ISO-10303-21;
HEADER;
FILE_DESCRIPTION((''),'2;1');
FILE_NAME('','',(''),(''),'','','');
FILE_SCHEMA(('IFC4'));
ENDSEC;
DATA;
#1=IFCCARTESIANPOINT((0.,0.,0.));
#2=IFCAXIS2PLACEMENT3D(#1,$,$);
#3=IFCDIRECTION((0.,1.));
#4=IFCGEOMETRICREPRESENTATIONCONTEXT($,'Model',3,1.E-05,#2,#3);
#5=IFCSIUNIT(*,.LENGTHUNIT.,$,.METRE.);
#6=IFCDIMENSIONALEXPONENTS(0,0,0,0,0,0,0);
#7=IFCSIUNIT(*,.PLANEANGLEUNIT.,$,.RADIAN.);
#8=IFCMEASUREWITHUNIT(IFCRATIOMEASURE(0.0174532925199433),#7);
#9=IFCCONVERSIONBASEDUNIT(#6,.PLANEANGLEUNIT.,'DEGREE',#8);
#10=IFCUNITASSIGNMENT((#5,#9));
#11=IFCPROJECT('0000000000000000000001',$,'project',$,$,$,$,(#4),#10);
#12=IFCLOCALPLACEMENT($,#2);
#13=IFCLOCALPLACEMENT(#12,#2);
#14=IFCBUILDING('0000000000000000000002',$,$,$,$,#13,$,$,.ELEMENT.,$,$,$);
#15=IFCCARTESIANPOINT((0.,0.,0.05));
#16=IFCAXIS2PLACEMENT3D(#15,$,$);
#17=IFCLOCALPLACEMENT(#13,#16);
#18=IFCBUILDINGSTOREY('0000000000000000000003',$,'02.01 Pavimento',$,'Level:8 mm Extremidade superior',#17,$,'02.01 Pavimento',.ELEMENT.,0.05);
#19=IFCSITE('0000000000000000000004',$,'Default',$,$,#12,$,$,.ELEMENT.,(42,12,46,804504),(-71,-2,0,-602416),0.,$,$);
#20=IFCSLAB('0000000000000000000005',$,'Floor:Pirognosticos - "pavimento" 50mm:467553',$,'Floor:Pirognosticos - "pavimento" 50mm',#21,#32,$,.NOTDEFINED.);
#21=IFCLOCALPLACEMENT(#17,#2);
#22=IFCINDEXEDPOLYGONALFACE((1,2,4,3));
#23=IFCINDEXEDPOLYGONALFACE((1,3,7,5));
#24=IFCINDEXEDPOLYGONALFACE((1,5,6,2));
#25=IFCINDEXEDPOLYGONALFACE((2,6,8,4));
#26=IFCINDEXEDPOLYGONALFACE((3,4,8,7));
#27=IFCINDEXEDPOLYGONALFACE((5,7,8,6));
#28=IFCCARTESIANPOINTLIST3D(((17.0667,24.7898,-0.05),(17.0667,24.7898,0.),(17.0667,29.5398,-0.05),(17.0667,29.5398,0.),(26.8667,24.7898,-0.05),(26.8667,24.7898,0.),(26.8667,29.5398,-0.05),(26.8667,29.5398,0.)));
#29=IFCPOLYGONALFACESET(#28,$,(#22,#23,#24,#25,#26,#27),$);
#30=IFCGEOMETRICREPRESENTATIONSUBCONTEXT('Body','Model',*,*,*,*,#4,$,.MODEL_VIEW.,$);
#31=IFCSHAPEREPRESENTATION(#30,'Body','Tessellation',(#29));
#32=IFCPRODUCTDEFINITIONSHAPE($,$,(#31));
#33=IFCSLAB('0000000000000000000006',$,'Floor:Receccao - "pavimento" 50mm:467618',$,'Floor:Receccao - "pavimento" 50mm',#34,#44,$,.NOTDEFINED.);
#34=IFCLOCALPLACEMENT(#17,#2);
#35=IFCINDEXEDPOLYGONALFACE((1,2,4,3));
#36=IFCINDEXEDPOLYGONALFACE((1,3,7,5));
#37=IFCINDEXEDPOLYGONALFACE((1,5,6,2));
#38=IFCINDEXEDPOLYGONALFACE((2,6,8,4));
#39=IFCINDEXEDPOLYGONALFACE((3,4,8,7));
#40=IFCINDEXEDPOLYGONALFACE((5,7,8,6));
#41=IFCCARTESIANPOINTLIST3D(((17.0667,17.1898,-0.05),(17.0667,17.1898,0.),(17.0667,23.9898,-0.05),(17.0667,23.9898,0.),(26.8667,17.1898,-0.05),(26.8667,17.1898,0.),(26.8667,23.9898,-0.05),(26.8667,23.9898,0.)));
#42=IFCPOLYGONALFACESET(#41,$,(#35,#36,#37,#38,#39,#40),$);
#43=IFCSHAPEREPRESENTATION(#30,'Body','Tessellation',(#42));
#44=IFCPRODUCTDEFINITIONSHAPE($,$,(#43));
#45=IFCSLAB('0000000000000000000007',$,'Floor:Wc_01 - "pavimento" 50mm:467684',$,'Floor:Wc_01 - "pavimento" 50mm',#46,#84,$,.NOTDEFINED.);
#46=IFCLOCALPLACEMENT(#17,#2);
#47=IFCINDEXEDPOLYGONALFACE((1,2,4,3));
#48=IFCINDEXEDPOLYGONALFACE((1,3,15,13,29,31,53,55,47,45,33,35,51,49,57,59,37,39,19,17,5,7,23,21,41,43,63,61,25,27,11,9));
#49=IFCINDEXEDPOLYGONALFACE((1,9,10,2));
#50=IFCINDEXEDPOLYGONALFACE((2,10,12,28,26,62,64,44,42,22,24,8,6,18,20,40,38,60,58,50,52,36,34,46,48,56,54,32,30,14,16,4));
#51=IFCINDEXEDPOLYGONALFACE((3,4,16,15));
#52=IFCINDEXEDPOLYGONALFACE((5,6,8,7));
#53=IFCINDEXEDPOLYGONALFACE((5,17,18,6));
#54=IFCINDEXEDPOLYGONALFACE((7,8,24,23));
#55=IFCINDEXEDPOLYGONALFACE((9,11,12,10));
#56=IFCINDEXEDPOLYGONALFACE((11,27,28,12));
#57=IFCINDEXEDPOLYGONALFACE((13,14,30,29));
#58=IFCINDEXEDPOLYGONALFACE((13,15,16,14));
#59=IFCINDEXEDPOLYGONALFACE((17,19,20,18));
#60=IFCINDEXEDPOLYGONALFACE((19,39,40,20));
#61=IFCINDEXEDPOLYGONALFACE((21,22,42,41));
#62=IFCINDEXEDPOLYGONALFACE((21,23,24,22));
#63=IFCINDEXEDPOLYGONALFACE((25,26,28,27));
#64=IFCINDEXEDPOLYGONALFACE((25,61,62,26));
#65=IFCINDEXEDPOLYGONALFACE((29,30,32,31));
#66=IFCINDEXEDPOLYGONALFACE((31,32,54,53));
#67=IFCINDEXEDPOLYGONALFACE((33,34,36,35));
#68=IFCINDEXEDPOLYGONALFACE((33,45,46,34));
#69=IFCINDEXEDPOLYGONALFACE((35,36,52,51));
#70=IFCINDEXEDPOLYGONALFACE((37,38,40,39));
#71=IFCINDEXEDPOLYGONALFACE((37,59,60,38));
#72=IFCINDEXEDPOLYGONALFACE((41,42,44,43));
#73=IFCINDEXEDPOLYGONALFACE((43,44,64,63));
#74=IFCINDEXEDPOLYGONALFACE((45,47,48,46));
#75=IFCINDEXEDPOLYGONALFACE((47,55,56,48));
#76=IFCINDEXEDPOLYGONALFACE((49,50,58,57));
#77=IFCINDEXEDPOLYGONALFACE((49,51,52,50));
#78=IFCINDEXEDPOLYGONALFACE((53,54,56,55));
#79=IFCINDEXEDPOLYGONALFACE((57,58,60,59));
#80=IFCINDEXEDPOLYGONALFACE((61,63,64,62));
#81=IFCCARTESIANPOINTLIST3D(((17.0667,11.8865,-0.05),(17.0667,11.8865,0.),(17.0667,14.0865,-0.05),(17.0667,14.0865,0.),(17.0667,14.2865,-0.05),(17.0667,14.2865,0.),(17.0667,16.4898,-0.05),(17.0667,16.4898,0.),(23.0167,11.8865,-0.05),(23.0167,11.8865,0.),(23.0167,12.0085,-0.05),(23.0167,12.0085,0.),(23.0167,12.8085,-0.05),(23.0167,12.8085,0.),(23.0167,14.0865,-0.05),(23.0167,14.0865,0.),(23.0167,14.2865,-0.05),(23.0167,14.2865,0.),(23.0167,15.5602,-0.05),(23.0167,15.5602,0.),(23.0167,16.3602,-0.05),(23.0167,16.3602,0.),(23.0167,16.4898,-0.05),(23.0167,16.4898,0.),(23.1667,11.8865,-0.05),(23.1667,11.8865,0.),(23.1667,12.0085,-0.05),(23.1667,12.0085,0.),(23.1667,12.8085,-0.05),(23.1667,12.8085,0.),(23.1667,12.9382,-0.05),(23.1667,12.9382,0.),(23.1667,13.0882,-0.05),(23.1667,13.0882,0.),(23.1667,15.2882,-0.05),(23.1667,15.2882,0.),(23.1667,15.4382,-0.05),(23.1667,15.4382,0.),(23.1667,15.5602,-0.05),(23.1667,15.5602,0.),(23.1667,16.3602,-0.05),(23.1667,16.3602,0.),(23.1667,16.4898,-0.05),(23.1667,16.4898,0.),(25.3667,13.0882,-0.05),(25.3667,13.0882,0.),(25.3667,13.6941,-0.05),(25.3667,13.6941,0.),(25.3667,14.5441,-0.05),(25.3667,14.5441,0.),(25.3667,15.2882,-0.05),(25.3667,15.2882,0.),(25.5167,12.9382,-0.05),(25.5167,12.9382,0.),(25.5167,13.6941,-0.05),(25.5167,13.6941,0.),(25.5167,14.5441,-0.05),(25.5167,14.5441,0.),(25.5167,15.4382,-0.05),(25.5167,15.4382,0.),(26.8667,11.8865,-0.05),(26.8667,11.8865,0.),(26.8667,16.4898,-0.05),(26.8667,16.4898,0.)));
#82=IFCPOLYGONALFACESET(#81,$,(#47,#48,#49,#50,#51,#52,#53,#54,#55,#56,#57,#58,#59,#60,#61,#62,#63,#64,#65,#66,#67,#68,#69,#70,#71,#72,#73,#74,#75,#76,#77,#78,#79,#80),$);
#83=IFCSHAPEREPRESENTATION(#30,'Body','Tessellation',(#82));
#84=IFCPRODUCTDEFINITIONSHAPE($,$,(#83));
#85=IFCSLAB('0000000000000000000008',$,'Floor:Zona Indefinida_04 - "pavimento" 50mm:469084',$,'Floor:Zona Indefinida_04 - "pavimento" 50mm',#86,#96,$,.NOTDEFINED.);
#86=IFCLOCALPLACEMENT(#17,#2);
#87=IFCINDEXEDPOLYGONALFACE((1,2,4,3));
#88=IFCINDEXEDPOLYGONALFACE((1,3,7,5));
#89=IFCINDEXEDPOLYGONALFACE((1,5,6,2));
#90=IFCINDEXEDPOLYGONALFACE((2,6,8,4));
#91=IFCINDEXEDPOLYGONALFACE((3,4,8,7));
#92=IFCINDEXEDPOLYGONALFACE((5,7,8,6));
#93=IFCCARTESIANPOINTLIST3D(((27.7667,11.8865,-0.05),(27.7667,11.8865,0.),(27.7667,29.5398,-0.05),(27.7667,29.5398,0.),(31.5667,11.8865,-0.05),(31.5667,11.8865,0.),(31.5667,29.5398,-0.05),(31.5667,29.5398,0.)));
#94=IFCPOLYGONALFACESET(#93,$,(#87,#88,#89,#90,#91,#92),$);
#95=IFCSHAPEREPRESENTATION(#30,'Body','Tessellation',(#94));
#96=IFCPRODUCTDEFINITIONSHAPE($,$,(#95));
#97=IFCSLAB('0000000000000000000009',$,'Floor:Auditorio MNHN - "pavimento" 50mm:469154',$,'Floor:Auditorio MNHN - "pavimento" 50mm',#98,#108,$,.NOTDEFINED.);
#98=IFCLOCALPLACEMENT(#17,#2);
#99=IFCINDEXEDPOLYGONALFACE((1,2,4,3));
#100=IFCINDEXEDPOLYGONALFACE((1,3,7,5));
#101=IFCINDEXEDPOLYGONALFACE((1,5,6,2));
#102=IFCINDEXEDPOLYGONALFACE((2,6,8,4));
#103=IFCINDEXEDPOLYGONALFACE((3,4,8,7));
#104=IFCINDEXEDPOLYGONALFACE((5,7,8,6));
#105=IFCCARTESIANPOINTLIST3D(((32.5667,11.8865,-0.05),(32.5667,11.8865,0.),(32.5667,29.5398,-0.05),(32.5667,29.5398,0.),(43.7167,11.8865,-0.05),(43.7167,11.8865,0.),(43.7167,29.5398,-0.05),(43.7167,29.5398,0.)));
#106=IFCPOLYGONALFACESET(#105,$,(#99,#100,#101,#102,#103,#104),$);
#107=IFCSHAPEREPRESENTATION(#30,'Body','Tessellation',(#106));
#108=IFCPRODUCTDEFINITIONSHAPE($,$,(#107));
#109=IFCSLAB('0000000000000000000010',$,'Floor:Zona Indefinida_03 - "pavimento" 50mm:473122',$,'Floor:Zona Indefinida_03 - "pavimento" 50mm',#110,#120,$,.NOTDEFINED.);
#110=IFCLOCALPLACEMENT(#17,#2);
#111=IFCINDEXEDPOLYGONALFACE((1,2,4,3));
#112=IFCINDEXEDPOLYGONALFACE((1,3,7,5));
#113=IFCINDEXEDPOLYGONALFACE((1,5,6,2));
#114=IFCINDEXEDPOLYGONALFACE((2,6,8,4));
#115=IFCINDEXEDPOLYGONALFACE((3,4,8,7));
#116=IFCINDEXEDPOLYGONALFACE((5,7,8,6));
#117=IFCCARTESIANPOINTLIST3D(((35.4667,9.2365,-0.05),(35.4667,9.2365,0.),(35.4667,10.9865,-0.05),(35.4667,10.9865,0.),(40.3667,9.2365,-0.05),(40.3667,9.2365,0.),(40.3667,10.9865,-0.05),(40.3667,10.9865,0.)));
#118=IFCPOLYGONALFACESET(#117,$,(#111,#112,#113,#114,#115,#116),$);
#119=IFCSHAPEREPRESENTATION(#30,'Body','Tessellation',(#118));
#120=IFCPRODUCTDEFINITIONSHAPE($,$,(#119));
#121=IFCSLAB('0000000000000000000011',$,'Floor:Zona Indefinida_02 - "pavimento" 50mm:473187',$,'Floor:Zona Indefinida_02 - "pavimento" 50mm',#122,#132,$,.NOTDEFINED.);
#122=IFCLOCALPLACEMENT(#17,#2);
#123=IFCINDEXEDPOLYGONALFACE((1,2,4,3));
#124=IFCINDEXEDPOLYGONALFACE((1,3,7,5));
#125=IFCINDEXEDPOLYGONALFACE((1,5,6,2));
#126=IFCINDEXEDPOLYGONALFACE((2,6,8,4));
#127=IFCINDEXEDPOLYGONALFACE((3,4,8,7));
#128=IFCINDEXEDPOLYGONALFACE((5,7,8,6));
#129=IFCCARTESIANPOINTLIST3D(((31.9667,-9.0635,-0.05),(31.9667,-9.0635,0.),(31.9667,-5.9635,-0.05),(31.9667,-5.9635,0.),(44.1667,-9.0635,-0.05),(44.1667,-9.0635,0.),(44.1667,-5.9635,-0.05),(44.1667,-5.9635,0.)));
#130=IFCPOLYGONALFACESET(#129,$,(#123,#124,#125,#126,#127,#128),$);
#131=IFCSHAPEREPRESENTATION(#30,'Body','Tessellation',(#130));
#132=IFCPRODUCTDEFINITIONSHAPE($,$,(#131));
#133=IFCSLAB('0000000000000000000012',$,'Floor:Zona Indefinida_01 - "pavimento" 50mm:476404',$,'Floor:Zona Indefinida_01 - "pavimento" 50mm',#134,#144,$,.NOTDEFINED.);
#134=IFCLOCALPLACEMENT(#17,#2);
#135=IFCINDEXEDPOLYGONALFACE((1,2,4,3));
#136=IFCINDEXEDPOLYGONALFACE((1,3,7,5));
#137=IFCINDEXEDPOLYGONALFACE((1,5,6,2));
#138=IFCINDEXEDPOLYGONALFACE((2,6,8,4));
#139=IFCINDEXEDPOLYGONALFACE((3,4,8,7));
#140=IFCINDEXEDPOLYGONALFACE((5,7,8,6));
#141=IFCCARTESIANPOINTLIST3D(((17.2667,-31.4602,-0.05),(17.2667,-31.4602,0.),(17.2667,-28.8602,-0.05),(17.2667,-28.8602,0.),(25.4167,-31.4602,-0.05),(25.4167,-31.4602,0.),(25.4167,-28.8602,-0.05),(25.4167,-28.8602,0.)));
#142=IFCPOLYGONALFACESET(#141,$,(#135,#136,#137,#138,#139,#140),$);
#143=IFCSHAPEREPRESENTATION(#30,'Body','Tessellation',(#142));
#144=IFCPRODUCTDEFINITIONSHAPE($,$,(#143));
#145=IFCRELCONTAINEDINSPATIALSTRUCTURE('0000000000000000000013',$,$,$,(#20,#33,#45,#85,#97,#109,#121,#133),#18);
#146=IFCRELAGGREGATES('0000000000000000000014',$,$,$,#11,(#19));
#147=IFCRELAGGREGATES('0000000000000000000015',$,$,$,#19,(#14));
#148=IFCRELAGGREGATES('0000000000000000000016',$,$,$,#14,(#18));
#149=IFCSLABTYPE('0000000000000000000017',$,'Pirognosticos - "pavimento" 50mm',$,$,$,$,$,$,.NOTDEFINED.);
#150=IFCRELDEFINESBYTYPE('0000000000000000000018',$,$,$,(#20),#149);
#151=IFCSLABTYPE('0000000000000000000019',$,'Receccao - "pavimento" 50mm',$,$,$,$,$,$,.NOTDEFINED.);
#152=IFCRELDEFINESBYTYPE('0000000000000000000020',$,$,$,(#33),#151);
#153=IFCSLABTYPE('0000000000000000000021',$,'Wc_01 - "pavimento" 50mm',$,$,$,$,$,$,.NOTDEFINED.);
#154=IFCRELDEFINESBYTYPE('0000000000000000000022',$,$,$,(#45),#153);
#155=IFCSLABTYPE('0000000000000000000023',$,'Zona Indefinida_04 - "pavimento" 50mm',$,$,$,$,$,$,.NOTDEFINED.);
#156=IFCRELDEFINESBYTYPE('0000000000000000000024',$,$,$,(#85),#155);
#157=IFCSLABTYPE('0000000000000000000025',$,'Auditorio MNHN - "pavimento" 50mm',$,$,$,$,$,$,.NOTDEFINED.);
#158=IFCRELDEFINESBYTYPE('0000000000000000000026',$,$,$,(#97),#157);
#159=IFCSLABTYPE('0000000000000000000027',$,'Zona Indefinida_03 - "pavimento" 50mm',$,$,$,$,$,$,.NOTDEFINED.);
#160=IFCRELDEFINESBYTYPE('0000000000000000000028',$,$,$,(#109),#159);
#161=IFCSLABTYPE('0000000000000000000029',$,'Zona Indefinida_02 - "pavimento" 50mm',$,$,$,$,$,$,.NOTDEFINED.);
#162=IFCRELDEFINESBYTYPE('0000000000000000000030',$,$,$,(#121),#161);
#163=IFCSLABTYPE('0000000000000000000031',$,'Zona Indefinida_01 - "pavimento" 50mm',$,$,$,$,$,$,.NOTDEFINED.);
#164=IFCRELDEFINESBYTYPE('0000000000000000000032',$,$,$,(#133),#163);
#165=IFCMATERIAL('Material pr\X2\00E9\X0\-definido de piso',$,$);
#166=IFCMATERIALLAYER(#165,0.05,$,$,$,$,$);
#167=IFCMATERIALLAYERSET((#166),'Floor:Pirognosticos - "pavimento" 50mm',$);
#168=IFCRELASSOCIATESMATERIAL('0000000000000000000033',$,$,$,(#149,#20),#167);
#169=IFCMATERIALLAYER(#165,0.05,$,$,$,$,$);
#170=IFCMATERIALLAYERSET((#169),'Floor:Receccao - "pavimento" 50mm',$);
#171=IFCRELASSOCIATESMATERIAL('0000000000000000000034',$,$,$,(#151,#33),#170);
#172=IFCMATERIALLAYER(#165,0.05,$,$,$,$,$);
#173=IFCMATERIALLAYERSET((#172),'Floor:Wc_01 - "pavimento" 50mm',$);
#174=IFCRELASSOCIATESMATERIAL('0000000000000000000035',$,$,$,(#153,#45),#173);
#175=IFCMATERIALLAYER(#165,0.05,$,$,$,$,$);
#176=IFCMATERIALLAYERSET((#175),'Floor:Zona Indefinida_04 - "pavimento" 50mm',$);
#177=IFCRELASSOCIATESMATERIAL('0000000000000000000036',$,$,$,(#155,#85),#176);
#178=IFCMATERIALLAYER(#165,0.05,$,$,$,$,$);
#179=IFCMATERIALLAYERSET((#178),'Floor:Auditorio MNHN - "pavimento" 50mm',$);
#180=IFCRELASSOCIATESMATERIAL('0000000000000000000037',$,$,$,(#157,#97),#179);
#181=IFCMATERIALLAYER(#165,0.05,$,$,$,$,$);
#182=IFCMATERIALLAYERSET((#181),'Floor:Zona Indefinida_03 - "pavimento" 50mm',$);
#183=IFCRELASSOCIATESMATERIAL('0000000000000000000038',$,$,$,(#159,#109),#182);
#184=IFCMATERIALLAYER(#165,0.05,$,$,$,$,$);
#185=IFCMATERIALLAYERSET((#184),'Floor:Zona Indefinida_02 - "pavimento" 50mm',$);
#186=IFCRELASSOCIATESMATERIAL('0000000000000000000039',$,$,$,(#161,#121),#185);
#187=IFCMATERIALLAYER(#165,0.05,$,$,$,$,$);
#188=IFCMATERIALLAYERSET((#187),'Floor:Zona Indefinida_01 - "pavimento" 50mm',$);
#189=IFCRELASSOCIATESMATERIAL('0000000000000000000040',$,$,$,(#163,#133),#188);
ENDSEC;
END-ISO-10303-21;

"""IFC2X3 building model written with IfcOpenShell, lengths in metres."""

from ifc_helpers import new_model, entity, si_unit, converted_unit, direction, frame, frame_2d, origin, origin_2d_with_axis, place, context, subcontext, project, spatial, polyline, rectangle, outline, extrude, material, layer, layer_set, layer_usage, type_object, element, save


model = new_model("IFC2X3")

# Units and contexts
model_context = context("Model", 3, precision=1e-05, world=origin(), true_north=direction((0.0, 1.0)))
body_context = subcontext(model_context, "Body", "Model", "MODEL_VIEW")
ifc_project = project(units=[si_unit("LENGTHUNIT", "METRE"), converted_unit("PLANEANGLEUNIT", "DEGREE", entity("IfcRatioMeasure", 0.0174532925199433), si_unit("PLANEANGLEUNIT", "RADIAN"), dimensions=[0, 0, 0, 0, 0, 0, 0])], contexts=[model_context])

# Site, building, storey
site_placement = place(None, origin())
site = spatial("IfcSite", under=ifc_project, at=site_placement, Name="Default", CompositionType="ELEMENT", RefLatitude=(42, 12, 46, 804504), RefLongitude=(-71, -2, 0, -602416), RefElevation=0.0)
building_placement = place(site_placement, origin())
building = spatial("IfcBuilding", under=site, at=building_placement, CompositionType="ELEMENT")
storey_placement = place(building_placement, frame((0.0, 0.0, 0.05)))
storey = spatial("IfcBuildingStorey", under=building, at=storey_placement, Name="02.01 Pavimento", ObjectType="Level:8 mm Extremidade superior", LongName="02.01 Pavimento", CompositionType="ELEMENT", Elevation=0.05)

# Slabs
ifc_material_1 = material(Name="Material pré-definido de piso")
ifc_layer_1 = layer(ifc_material_1, 0.05)
ifc_layer_set_1 = layer_set([ifc_layer_1], Name="Floor:Pirognosticos - \"pavimento\" 50mm")
ifc_layer_usage_1 = layer_usage(ifc_layer_set_1, "AXIS3", "POSITIVE", 0.0)
slab_type_1 = type_object("IfcSlabType", Name="Pirognosticos - \"pavimento\" 50mm", PredefinedType="NOTDEFINED", material=ifc_layer_set_1)
slab_1_placement = place(storey_placement, origin())
element("IfcSlab", 1, at=slab_1_placement, inside=storey, type_object=slab_type_1, material=ifc_layer_usage_1, Name="Floor:Pirognosticos - \"pavimento\" 50mm:467553", ObjectType="Floor:Pirognosticos - \"pavimento\" 50mm", PredefinedType="NOTDEFINED", context=body_context, shape_type="SweptSolid", body=[
    extrude(rectangle(XDim=4.75, YDim=9.8, at=frame_2d((0.0, 0.0), x_axis=(1.0, 0.0))), frame((21.9667, 27.1648, 0.0), z_axis=(0.0, 0.0, -1.0), x_axis=(0.0, 1.0, 0.0)), (0.0, 0.0, 1.0), 0.05),
])
ifc_layer_2 = layer(ifc_material_1, 0.05)
ifc_layer_set_2 = layer_set([ifc_layer_2], Name="Floor:Receccao - \"pavimento\" 50mm")
ifc_layer_usage_2 = layer_usage(ifc_layer_set_2, "AXIS3", "POSITIVE", 0.0)
slab_type_2 = type_object("IfcSlabType", Name="Receccao - \"pavimento\" 50mm", PredefinedType="NOTDEFINED", material=ifc_layer_set_2)
slab_2_placement = place(storey_placement, origin())
element("IfcSlab", 2, at=slab_2_placement, inside=storey, type_object=slab_type_2, material=ifc_layer_usage_2, Name="Floor:Receccao - \"pavimento\" 50mm:467618", ObjectType="Floor:Receccao - \"pavimento\" 50mm", PredefinedType="NOTDEFINED", context=body_context, shape_type="SweptSolid", body=[
    extrude(rectangle(XDim=6.8, YDim=9.8, at=frame_2d((0.0, 0.0), x_axis=(1.0, 0.0))), frame((21.9667, 20.5898, 0.0), z_axis=(0.0, 0.0, -1.0), x_axis=(0.0, 1.0, 0.0)), (0.0, 0.0, 1.0), 0.05),
])
ifc_layer_3 = layer(ifc_material_1, 0.05)
ifc_layer_set_3 = layer_set([ifc_layer_3], Name="Floor:Wc_01 - \"pavimento\" 50mm")
ifc_layer_usage_3 = layer_usage(ifc_layer_set_3, "AXIS3", "POSITIVE", 0.0)
slab_type_3 = type_object("IfcSlabType", Name="Wc_01 - \"pavimento\" 50mm", PredefinedType="NOTDEFINED", material=ifc_layer_set_3)
slab_3_placement = place(storey_placement, origin())
element("IfcSlab", 3, at=slab_3_placement, inside=storey, type_object=slab_type_3, material=ifc_layer_usage_3, Name="Floor:Wc_01 - \"pavimento\" 50mm:467684", ObjectType="Floor:Wc_01 - \"pavimento\" 50mm", PredefinedType="NOTDEFINED", context=body_context, shape_type="SweptSolid", body=[
    extrude(outline(polyline([(0.1081, -6.1), (2.3115, -6.1), (2.3115, -0.15), (2.1818, -0.15), (2.1818, 0.0), (2.3115, 0.0), (2.3115, 3.7), (-2.2919, 3.7), (-2.2919, 0.0), (-2.1698, 0.0), (-2.1698, -0.15), (-2.2919, -0.15), (-2.2919, -6.1), (-0.0919, -6.1), (-0.0919, -0.15), (-1.3698, -0.15), (-1.3698, 0.0), (-1.2402, 0.0), (-1.2402, 2.35), (-0.4843, 2.35), (-0.4843, 2.2), (-1.0902, 2.2), (-1.0902, 0.0), (1.1098, 0.0), (1.1098, 2.2), (0.3657, 2.2), (0.3657, 2.35), (1.2598, 2.35), (1.2598, 0.0), (1.3818, 0.0), (1.3818, -0.15), (0.1081, -0.15), (0.1081, -6.1)])), frame((23.1667, 14.1784, 0.0), z_axis=(0.0, 0.0, -1.0), x_axis=(0.0, 1.0, 0.0)), (0.0, 0.0, 1.0), 0.05),
])
ifc_layer_4 = layer(ifc_material_1, 0.05)
ifc_layer_set_4 = layer_set([ifc_layer_4], Name="Floor:Zona Indefinida_04 - \"pavimento\" 50mm")
ifc_layer_usage_4 = layer_usage(ifc_layer_set_4, "AXIS3", "POSITIVE", 0.0)
slab_type_4 = type_object("IfcSlabType", Name="Zona Indefinida_04 - \"pavimento\" 50mm", PredefinedType="NOTDEFINED", material=ifc_layer_set_4)
slab_4_placement = place(storey_placement, origin())
element("IfcSlab", 4, at=slab_4_placement, inside=storey, type_object=slab_type_4, material=ifc_layer_usage_4, Name="Floor:Zona Indefinida_04 - \"pavimento\" 50mm:469084", ObjectType="Floor:Zona Indefinida_04 - \"pavimento\" 50mm", PredefinedType="NOTDEFINED", context=body_context, shape_type="SweptSolid", body=[
    extrude(rectangle(XDim=17.6533, YDim=3.8, at=frame_2d((0.0, 0.0), x_axis=(1.0, 0.0))), frame((29.6667, 20.7132, 0.0), z_axis=(0.0, 0.0, -1.0), x_axis=(0.0, 1.0, 0.0)), (0.0, 0.0, 1.0), 0.05),
])
ifc_layer_5 = layer(ifc_material_1, 0.05)
ifc_layer_set_5 = layer_set([ifc_layer_5], Name="Floor:Auditorio MNHN - \"pavimento\" 50mm")
ifc_layer_usage_5 = layer_usage(ifc_layer_set_5, "AXIS3", "POSITIVE", 0.0)
slab_type_5 = type_object("IfcSlabType", Name="Auditorio MNHN - \"pavimento\" 50mm", PredefinedType="NOTDEFINED", material=ifc_layer_set_5)
slab_5_placement = place(storey_placement, origin())
element("IfcSlab", 5, at=slab_5_placement, inside=storey, type_object=slab_type_5, material=ifc_layer_usage_5, Name="Floor:Auditorio MNHN - \"pavimento\" 50mm:469154", ObjectType="Floor:Auditorio MNHN - \"pavimento\" 50mm", PredefinedType="NOTDEFINED", context=body_context, shape_type="SweptSolid", body=[
    extrude(rectangle(XDim=17.6533, YDim=11.15, at=frame_2d((0.0, 0.0), x_axis=(1.0, 0.0))), frame((38.1417, 20.7132, 0.0), z_axis=(0.0, 0.0, -1.0), x_axis=(0.0, 1.0, 0.0)), (0.0, 0.0, 1.0), 0.05),
])
ifc_layer_6 = layer(ifc_material_1, 0.05)
ifc_layer_set_6 = layer_set([ifc_layer_6], Name="Floor:Zona Indefinida_03 - \"pavimento\" 50mm")
ifc_layer_usage_6 = layer_usage(ifc_layer_set_6, "AXIS3", "POSITIVE", 0.0)
slab_type_6 = type_object("IfcSlabType", Name="Zona Indefinida_03 - \"pavimento\" 50mm", PredefinedType="NOTDEFINED", material=ifc_layer_set_6)
slab_6_placement = place(storey_placement, origin())
element("IfcSlab", 6, at=slab_6_placement, inside=storey, type_object=slab_type_6, material=ifc_layer_usage_6, Name="Floor:Zona Indefinida_03 - \"pavimento\" 50mm:473122", ObjectType="Floor:Zona Indefinida_03 - \"pavimento\" 50mm", PredefinedType="NOTDEFINED", context=body_context, shape_type="SweptSolid", body=[
    extrude(rectangle(XDim=1.75, YDim=4.9, at=frame_2d((0.0, 0.0), x_axis=(1.0, 0.0))), frame((37.9167, 10.1115, 0.0), z_axis=(0.0, 0.0, -1.0), x_axis=(0.0, 1.0, 0.0)), (0.0, 0.0, 1.0), 0.05),
])
ifc_layer_7 = layer(ifc_material_1, 0.05)
ifc_layer_set_7 = layer_set([ifc_layer_7], Name="Floor:Zona Indefinida_02 - \"pavimento\" 50mm")
ifc_layer_usage_7 = layer_usage(ifc_layer_set_7, "AXIS3", "POSITIVE", 0.0)
slab_type_7 = type_object("IfcSlabType", Name="Zona Indefinida_02 - \"pavimento\" 50mm", PredefinedType="NOTDEFINED", material=ifc_layer_set_7)
slab_7_placement = place(storey_placement, origin())
element("IfcSlab", 7, at=slab_7_placement, inside=storey, type_object=slab_type_7, material=ifc_layer_usage_7, Name="Floor:Zona Indefinida_02 - \"pavimento\" 50mm:473187", ObjectType="Floor:Zona Indefinida_02 - \"pavimento\" 50mm", PredefinedType="NOTDEFINED", context=body_context, shape_type="SweptSolid", body=[
    extrude(rectangle(XDim=3.1, YDim=12.2, at=origin_2d_with_axis()), frame((38.0667, -7.5135, 0.0), z_axis=(0.0, 0.0, -1.0), x_axis=(0.0, 1.0, 0.0)), (0.0, 0.0, 1.0), 0.05),
])
ifc_layer_8 = layer(ifc_material_1, 0.05)
ifc_layer_set_8 = layer_set([ifc_layer_8], Name="Floor:Zona Indefinida_01 - \"pavimento\" 50mm")
ifc_layer_usage_8 = layer_usage(ifc_layer_set_8, "AXIS3", "POSITIVE", 0.0)
slab_type_8 = type_object("IfcSlabType", Name="Zona Indefinida_01 - \"pavimento\" 50mm", PredefinedType="NOTDEFINED", material=ifc_layer_set_8)
slab_8_placement = place(storey_placement, origin())
element("IfcSlab", 8, at=slab_8_placement, inside=storey, type_object=slab_type_8, material=ifc_layer_usage_8, Name="Floor:Zona Indefinida_01 - \"pavimento\" 50mm:476404", ObjectType="Floor:Zona Indefinida_01 - \"pavimento\" 50mm", PredefinedType="NOTDEFINED", context=body_context, shape_type="SweptSolid", body=[
    extrude(rectangle(XDim=2.6, YDim=8.15, at=frame_2d((0.0, 0.0), x_axis=(1.0, 0.0))), frame((21.3417, -30.1602, 0.0), z_axis=(0.0, 0.0, -1.0), x_axis=(0.0, 1.0, 0.0)), (0.0, 0.0, 1.0), 0.05),
])

save(model, "model.ifc")
